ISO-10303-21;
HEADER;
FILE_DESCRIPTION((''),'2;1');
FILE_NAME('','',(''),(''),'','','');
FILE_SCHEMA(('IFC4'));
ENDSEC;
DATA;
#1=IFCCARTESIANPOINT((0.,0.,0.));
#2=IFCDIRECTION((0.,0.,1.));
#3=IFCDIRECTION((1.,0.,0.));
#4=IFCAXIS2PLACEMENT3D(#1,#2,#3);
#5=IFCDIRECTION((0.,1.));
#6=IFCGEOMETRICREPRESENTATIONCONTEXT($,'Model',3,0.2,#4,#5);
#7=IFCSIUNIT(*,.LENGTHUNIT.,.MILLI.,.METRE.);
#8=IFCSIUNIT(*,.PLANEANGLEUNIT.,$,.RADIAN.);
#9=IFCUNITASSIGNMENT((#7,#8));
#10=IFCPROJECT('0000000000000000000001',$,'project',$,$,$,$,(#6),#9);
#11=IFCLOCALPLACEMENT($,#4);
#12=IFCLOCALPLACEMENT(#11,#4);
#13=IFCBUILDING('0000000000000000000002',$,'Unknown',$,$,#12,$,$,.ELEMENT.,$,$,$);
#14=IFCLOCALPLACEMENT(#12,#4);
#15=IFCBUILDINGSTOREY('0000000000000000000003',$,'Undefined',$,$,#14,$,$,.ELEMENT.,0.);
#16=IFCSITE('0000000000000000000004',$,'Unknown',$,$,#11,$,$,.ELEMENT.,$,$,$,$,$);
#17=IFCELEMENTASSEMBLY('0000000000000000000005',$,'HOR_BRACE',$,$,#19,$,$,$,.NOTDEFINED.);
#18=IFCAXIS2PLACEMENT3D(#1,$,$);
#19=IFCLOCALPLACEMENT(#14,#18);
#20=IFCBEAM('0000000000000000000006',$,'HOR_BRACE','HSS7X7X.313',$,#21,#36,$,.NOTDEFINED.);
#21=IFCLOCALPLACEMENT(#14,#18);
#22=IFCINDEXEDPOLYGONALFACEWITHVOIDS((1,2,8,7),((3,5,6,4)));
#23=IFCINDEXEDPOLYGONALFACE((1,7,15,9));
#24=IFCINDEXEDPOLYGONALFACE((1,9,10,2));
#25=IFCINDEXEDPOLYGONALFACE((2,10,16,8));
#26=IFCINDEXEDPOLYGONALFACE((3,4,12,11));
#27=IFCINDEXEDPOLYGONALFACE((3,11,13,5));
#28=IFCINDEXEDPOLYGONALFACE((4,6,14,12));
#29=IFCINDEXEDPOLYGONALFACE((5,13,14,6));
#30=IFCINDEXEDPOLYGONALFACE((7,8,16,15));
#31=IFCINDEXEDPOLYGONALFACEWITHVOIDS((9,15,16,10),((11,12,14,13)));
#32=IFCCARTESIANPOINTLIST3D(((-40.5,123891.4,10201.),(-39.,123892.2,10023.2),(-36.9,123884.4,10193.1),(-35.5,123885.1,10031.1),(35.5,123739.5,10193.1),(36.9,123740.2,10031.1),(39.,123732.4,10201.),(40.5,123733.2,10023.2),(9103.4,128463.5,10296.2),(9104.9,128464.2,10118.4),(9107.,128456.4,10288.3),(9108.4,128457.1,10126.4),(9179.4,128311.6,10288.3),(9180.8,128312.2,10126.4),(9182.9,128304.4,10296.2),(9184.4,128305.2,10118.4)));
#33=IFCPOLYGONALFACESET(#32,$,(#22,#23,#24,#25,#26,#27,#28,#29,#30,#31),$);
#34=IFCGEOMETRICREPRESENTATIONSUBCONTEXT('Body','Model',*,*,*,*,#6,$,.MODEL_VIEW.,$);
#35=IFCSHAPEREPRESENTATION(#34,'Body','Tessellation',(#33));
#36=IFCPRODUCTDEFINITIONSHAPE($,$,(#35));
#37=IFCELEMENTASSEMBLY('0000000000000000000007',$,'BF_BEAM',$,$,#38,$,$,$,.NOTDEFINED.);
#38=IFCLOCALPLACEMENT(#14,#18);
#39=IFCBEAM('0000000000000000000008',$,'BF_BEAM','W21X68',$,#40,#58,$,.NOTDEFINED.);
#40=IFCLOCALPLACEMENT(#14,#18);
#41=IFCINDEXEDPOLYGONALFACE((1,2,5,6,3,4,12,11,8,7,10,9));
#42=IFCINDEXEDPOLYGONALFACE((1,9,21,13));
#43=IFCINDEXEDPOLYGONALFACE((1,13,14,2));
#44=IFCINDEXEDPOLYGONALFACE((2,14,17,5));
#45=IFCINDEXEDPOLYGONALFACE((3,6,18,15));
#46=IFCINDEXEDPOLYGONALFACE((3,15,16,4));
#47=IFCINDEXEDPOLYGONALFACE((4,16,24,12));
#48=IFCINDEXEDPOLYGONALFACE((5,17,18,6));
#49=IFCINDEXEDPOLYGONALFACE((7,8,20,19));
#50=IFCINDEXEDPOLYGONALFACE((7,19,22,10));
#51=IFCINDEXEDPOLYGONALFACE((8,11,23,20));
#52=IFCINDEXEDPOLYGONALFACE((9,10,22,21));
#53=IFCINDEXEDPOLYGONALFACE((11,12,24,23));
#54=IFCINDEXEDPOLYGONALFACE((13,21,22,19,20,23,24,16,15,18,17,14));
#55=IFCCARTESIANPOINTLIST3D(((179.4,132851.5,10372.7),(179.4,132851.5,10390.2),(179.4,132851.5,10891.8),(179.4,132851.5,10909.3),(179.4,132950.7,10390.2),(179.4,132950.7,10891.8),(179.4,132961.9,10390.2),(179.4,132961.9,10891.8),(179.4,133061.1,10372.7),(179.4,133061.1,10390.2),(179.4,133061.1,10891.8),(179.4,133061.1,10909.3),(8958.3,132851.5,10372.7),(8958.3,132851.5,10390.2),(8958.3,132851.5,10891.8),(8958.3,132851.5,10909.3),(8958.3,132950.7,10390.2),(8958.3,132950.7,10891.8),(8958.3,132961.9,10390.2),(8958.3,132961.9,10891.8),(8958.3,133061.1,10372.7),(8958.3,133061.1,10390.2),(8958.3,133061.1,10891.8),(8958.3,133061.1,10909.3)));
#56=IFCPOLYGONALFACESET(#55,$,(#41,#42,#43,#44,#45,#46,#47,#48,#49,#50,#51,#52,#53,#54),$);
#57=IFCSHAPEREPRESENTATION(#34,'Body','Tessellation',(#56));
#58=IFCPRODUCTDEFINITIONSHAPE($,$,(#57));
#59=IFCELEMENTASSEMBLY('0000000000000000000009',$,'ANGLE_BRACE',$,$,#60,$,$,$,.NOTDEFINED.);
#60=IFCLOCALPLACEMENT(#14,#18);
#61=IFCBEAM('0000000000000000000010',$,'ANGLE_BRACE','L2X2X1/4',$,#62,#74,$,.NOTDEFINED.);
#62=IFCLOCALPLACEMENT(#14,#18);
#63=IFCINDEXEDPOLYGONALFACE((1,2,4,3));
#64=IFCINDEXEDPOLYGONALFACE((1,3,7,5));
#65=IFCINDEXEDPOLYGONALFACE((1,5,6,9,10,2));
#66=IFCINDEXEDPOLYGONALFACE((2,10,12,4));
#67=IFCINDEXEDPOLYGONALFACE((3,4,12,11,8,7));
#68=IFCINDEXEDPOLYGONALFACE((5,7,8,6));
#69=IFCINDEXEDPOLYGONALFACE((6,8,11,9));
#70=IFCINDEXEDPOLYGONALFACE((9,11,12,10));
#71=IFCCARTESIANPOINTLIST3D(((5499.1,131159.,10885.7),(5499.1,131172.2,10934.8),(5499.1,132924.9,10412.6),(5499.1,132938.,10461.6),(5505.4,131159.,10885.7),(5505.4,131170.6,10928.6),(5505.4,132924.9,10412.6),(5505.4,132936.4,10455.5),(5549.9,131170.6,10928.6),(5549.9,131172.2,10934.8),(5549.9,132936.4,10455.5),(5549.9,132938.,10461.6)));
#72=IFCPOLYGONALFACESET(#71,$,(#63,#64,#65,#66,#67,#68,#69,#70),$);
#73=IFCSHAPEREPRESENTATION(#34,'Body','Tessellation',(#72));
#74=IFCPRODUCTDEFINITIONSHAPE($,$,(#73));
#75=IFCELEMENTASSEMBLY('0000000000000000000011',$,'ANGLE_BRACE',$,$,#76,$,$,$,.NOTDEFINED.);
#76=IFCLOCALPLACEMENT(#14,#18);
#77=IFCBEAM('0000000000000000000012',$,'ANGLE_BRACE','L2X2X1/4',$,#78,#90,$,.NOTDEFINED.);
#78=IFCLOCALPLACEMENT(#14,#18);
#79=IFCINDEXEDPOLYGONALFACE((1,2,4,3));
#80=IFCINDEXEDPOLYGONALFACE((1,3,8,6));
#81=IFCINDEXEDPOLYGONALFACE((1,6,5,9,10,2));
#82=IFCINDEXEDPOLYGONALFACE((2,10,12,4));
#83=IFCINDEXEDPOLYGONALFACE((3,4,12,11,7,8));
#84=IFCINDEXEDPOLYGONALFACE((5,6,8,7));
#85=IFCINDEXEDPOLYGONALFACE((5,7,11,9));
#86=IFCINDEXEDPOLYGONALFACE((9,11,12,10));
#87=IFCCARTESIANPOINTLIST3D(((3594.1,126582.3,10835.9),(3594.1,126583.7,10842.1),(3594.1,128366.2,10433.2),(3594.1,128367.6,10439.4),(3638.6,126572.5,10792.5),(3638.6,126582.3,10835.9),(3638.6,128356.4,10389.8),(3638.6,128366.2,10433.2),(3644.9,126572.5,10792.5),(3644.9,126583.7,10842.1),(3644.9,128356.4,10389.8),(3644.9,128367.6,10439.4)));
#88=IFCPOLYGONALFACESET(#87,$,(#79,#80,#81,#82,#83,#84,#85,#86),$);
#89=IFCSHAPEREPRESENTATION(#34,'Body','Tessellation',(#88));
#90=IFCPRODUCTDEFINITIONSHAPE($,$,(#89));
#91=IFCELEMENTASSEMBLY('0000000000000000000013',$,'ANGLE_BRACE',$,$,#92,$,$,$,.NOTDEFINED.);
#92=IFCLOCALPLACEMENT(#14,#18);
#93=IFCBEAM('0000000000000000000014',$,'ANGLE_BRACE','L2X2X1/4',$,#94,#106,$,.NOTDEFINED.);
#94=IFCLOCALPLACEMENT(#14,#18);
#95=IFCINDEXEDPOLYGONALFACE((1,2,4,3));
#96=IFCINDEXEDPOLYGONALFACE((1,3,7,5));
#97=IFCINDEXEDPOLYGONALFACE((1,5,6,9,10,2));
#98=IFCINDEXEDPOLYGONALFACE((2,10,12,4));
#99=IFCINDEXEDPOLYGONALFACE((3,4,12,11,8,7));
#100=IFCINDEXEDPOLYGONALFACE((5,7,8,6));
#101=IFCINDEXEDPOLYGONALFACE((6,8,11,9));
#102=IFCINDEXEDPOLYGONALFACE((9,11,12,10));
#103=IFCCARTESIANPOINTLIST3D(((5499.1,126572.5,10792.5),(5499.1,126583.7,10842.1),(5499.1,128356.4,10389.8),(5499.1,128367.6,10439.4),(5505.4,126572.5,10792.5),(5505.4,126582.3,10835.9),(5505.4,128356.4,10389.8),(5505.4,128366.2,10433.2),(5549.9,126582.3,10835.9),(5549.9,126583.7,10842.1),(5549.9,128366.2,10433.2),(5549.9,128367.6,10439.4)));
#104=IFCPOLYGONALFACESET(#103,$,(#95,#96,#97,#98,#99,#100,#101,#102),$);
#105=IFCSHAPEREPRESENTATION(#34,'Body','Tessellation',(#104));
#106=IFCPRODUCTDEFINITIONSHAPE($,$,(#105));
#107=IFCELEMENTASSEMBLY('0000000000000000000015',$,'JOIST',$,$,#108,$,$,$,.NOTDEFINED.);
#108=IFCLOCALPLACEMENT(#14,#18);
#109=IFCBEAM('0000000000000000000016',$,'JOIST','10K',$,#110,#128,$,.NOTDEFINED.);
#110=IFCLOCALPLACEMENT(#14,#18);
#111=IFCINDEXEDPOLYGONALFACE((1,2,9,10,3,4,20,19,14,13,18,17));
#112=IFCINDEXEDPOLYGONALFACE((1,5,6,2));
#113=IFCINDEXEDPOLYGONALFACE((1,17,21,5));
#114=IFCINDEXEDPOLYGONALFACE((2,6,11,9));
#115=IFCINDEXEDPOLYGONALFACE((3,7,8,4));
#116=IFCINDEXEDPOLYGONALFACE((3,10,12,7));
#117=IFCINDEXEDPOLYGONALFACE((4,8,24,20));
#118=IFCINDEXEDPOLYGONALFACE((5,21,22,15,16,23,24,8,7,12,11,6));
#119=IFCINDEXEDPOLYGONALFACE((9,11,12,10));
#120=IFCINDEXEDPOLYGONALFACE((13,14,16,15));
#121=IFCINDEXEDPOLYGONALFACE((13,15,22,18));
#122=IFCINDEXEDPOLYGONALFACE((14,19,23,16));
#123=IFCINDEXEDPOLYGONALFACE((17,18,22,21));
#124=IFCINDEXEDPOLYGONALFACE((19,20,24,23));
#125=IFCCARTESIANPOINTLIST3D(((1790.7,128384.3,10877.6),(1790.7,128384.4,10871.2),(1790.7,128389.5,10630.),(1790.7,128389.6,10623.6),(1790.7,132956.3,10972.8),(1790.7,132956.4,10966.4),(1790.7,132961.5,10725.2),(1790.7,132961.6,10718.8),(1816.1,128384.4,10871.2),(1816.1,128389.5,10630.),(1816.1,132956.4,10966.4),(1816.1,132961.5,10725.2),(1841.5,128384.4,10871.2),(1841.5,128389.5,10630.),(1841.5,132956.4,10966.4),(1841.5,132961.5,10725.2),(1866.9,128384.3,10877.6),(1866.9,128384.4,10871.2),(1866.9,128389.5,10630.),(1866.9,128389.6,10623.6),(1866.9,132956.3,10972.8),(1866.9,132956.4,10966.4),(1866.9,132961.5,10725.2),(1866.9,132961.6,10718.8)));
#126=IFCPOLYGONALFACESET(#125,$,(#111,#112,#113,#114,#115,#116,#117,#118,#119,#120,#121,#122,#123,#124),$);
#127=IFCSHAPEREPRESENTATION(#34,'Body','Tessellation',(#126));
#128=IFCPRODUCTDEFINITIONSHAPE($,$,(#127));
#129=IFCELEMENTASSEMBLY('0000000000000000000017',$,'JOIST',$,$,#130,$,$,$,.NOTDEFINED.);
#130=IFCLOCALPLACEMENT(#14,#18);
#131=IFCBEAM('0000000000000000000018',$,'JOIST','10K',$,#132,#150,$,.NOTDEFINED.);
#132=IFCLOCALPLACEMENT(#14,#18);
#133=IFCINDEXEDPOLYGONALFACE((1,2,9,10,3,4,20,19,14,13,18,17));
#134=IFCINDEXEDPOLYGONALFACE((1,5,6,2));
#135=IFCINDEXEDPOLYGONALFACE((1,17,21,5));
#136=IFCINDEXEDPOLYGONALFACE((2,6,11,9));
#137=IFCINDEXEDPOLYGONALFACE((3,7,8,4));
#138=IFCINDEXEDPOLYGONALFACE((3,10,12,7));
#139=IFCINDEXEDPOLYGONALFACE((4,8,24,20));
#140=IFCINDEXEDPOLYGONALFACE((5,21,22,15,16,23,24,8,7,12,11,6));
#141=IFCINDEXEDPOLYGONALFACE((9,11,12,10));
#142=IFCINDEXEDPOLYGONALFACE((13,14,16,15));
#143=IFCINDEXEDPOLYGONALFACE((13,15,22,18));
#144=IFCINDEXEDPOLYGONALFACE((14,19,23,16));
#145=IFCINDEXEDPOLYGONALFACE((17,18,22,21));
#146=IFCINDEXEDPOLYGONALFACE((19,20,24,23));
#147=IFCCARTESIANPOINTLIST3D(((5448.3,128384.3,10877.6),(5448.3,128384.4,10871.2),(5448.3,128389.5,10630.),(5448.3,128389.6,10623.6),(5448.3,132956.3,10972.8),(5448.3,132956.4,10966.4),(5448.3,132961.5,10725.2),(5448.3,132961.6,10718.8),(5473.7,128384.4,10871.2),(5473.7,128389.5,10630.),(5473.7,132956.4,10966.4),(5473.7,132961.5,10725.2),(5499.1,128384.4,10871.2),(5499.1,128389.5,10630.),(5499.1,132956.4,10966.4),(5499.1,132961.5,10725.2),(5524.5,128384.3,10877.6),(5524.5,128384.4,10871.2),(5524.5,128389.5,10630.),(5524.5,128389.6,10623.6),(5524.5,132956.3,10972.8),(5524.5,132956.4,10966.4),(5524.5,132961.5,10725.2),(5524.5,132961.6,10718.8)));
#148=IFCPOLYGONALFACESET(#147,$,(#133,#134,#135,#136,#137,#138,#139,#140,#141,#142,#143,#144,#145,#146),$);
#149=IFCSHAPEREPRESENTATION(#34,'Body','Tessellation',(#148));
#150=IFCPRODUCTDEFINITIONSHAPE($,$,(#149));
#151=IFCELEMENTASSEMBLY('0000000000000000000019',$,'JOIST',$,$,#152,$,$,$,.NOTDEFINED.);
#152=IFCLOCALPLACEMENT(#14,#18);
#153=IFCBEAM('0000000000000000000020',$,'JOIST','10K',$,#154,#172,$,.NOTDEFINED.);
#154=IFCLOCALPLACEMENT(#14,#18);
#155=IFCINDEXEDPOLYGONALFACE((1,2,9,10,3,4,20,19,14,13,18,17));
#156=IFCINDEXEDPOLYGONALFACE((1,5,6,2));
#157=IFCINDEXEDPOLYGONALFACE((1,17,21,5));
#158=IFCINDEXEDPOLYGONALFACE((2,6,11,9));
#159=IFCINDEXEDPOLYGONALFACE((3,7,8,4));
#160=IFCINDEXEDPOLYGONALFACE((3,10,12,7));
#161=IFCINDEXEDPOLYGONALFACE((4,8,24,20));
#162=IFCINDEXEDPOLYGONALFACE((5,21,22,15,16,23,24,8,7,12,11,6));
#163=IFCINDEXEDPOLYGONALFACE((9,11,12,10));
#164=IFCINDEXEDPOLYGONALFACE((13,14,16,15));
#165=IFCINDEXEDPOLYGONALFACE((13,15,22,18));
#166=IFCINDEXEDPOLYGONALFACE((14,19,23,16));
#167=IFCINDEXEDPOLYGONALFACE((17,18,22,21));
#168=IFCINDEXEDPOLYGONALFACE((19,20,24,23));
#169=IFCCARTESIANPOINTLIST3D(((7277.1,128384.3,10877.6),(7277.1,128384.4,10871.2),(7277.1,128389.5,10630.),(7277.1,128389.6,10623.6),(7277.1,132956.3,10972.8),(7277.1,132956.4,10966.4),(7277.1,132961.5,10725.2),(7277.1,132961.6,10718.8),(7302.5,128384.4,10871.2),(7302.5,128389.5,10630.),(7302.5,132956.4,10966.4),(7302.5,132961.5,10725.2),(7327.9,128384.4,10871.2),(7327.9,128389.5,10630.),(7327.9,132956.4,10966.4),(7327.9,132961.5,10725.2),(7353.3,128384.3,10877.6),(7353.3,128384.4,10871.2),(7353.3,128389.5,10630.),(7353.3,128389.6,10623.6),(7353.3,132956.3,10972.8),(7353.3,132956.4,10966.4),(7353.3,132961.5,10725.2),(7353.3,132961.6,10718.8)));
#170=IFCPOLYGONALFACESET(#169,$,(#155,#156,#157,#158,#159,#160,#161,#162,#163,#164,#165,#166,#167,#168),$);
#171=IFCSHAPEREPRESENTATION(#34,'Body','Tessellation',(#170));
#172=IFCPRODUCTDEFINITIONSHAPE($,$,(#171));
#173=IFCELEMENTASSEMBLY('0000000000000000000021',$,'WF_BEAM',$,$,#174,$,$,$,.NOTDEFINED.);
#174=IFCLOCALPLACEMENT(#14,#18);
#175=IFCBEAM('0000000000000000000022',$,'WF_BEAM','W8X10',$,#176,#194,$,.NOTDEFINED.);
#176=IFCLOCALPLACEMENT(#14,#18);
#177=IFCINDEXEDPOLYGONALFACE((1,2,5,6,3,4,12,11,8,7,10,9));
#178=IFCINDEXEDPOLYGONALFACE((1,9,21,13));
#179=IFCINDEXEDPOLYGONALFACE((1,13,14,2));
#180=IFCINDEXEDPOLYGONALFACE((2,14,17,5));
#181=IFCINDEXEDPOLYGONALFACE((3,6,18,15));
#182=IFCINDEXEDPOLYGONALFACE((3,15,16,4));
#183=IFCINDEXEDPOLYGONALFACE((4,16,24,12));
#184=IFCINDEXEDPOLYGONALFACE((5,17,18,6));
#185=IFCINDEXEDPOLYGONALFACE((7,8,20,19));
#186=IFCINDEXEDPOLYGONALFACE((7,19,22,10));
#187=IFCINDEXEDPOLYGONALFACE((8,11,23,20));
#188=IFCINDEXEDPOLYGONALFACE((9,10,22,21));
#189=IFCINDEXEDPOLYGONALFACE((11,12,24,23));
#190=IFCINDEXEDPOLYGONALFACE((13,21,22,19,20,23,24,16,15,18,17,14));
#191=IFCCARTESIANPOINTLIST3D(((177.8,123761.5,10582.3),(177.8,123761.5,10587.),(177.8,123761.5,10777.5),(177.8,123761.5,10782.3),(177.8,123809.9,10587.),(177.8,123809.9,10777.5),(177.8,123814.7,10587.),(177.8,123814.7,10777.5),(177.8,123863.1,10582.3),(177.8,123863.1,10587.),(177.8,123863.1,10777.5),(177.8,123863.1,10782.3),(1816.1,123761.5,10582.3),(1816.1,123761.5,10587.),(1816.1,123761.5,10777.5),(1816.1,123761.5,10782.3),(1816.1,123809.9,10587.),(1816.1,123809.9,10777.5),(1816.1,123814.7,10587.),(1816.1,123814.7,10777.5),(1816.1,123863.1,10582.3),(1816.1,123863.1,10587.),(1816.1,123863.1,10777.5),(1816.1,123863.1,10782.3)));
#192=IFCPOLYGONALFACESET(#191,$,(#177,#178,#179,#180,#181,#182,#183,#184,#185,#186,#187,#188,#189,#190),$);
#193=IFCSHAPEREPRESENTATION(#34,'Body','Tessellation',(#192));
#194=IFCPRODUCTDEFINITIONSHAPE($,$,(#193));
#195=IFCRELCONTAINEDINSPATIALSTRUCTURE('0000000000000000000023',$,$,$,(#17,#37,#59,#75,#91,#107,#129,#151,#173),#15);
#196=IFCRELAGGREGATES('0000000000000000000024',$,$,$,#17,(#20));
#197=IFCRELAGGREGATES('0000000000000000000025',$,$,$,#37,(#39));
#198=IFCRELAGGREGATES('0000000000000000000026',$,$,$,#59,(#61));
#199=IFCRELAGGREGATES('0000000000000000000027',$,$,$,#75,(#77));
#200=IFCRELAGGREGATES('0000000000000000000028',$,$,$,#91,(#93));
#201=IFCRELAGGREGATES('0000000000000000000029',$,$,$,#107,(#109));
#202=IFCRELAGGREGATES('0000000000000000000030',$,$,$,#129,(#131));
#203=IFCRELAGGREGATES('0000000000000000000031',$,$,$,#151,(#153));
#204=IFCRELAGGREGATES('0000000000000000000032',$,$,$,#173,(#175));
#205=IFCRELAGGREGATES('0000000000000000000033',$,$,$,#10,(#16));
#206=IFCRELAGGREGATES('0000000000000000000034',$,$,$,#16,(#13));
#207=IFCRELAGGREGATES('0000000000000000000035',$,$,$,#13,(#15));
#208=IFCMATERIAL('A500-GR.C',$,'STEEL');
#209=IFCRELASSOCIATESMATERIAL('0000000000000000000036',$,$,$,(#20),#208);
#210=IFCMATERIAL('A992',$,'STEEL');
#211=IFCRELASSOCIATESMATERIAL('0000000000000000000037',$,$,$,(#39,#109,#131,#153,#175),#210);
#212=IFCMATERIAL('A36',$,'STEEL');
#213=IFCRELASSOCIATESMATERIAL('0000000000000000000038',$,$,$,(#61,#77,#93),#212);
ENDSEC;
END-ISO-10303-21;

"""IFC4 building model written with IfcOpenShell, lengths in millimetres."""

from ifc_helpers import new_model, si_unit, direction, frame, origin_with_axes, place, context, subcontext, project, spatial, line, indexed_curve, outline, extrude, material, element, aggregate, save


model = new_model("IFC4")

# Units and contexts
model_context = context("Model", 3, precision=0.2, world=origin_with_axes(), true_north=direction((0.0, 1.0)))
body_context = subcontext(model_context, "Body", "Model", "MODEL_VIEW")
ifc_project = project(units=[si_unit("LENGTHUNIT", "METRE", prefix="MILLI"), si_unit("PLANEANGLEUNIT", "RADIAN")], contexts=[model_context])

# Site, building, storey
site_placement = place(None, origin_with_axes())
site = spatial("IfcSite", under=ifc_project, at=site_placement, Name="Unknown", CompositionType="ELEMENT")
building_placement = place(site_placement, origin_with_axes())
building = spatial("IfcBuilding", under=site, at=building_placement, Name="Unknown", CompositionType="ELEMENT")
storey_placement = place(building_placement, origin_with_axes())
storey = spatial("IfcBuildingStorey", under=building, at=storey_placement, Name="Undefined", CompositionType="ELEMENT", Elevation=0.0)

# Element assemblies, beams
assembly_1_placement = place(storey_placement, frame((0.0, 123812.3, 10112.1), z_axis=(0.447218, -0.894425, 0.0), x_axis=(0.894386, 0.447199, 0.009317)))
assembly_1 = element("IfcElementAssembly", 1, at=assembly_1_placement, inside=storey, Name="HOR_BRACE", PredefinedType="NOTDEFINED")
ifc_material_1 = material(Name="A500-GR.C", Category="STEEL")
beam_1_placement = place(assembly_1_placement, origin_with_axes())
beam_1 = element("IfcBeam", 2, at=beam_1_placement, material=ifc_material_1, Name="HOR_BRACE", Description="HSS7X7X.313", PredefinedType="NOTDEFINED", context=body_context, shape_type="SolidModel", body=[
    extrude(outline(indexed_curve([(-88.9, -88.9), (88.9, -88.9), (88.9, 88.9), (-88.9, 88.9)], segments=[line(1, 2, 3, 4, 1)]), holes=[indexed_curve([(-81.0, -81.0), (-81.0, 81.0), (81.0, 81.0), (81.0, -81.0)], segments=[line(1, 2, 3, 4, 1)])]), frame((0.0, 0.0, 0.0), z_axis=(-1.0, 0.0, 0.0), x_axis=(0.0, 0.0, 1.0)), (0.0, 0.0, -1.0), 10223.7),
])
aggregate(assembly_1, [beam_1])
assembly_2_placement = place(storey_placement, frame((179.4, 132956.3, 10641.0), z_axis=(0.0, -1.0, 0.0), x_axis=(1.0, 0.0, 0.0)))
assembly_2 = element("IfcElementAssembly", 3, at=assembly_2_placement, inside=storey, Name="BF_BEAM", PredefinedType="NOTDEFINED")
ifc_material_2 = material(Name="A992", Category="STEEL")
beam_2_placement = place(assembly_2_placement, origin_with_axes())
beam_2 = element("IfcBeam", 4, at=beam_2_placement, material=ifc_material_2, Name="BF_BEAM", Description="W21X68", PredefinedType="NOTDEFINED", context=body_context, shape_type="SolidModel", body=[
    extrude(outline(indexed_curve([(-104.8, -268.3), (104.8, -268.3), (104.8, -250.8), (5.6, -250.8), (5.6, 250.8), (104.8, 250.8), (104.8, 268.3), (-104.8, 268.3), (-104.8, 250.8), (-5.6, 250.8), (-5.6, -250.8), (-104.8, -250.8)], segments=[line(1, 2, 3, 4, 5, 6, 7, 8, 9, 10, 11, 12, 1)])), frame((0.0, 0.0, 0.0), z_axis=(-1.0, 0.0, 0.0), x_axis=(0.0, 0.0, 1.0)), (0.0, 0.0, -1.0), 8778.9),
])
aggregate(assembly_2, [beam_2])
assembly_3_placement = place(storey_placement, frame((5524.5, 131165.6, 10910.2), z_axis=(0.0, -0.258819, -0.965926), x_axis=(0.0, 0.965926, -0.258819)))
assembly_3 = element("IfcElementAssembly", 5, at=assembly_3_placement, inside=storey, Name="ANGLE_BRACE", PredefinedType="NOTDEFINED")
ifc_material_3 = material(Name="A36", Category="STEEL")
beam_3_placement = place(assembly_3_placement, origin_with_axes())
beam_3 = element("IfcBeam", 6, at=beam_3_placement, material=ifc_material_3, Name="ANGLE_BRACE", Description="L2X2X1/4", PredefinedType="NOTDEFINED", context=body_context, shape_type="SolidModel", body=[
    extrude(outline(indexed_curve([(-25.4, -25.4), (25.4, -25.4), (25.4, -19.1), (-19.1, -19.1), (-19.1, 25.4), (-25.4, 25.4)], segments=[line(1, 2, 3, 4, 5, 6, 1)])), frame((0.0, 0.0, 0.0), z_axis=(-1.0, 0.0, 0.0), x_axis=(0.0, 0.0, 1.0)), (0.0, 0.0, -1.0), 1828.1),
])
aggregate(assembly_3, [beam_3])
assembly_4_placement = place(storey_placement, frame((3619.5, 126578.1, 10817.3), z_axis=(-1.0, 0.0, 0.0), x_axis=(0.0, 0.97546, -0.220178)))
assembly_4 = element("IfcElementAssembly", 7, at=assembly_4_placement, inside=storey, Name="ANGLE_BRACE", PredefinedType="NOTDEFINED")
beam_4_placement = place(assembly_4_placement, origin_with_axes())
beam_4 = element("IfcBeam", 8, at=beam_4_placement, material=ifc_material_3, Name="ANGLE_BRACE", Description="L2X2X1/4", PredefinedType="NOTDEFINED", context=body_context, shape_type="SolidModel", body=[
    extrude(outline(indexed_curve([(-25.4, -25.4), (25.4, -25.4), (25.4, -19.1), (-19.1, -19.1), (-19.1, 25.4), (-25.4, 25.4)], segments=[line(1, 2, 3, 4, 5, 6, 1)])), frame((0.0, 0.0, 0.0), z_axis=(-1.0, 0.0, 0.0), x_axis=(0.0, 0.0, 1.0)), (0.0, 0.0, -1.0), 1828.8),
])
aggregate(assembly_4, [beam_4])
assembly_5_placement = place(storey_placement, frame((5524.5, 126578.1, 10817.3), z_axis=(0.0, -0.220178, -0.97546), x_axis=(0.0, 0.97546, -0.220178)))
assembly_5 = element("IfcElementAssembly", 9, at=assembly_5_placement, inside=storey, Name="ANGLE_BRACE", PredefinedType="NOTDEFINED")
beam_5_placement = place(assembly_5_placement, origin_with_axes())
beam_5 = element("IfcBeam", 10, at=beam_5_placement, material=ifc_material_3, Name="ANGLE_BRACE", Description="L2X2X1/4", PredefinedType="NOTDEFINED", context=body_context, shape_type="SolidModel", body=[
    extrude(outline(indexed_curve([(-25.4, -25.4), (25.4, -25.4), (25.4, -19.1), (-19.1, -19.1), (-19.1, 25.4), (-25.4, 25.4)], segments=[line(1, 2, 3, 4, 5, 6, 1)])), frame((0.0, 0.0, 0.0), z_axis=(-1.0, 0.0, 0.0), x_axis=(0.0, 0.0, 1.0)), (0.0, 0.0, -1.0), 1828.8),
])
aggregate(assembly_5, [beam_5])
assembly_6_placement = place(storey_placement, frame((1828.8, 128386.9, 10750.6), z_axis=(1.0, 0.0, 0.0), x_axis=(0.0, 0.999783, 0.020819)))
assembly_6 = element("IfcElementAssembly", 11, at=assembly_6_placement, inside=storey, Name="JOIST", PredefinedType="NOTDEFINED")
beam_6_placement = place(assembly_6_placement, origin_with_axes())
beam_6 = element("IfcBeam", 12, at=beam_6_placement, material=ifc_material_2, Name="JOIST", Description="10K", PredefinedType="NOTDEFINED", context=body_context, shape_type="SolidModel", body=[
    extrude(outline(indexed_curve([(-38.1, -127.0), (38.1, -127.0), (38.1, -120.7), (12.7, -120.7), (12.7, 120.7), (38.1, 120.7), (38.1, 127.0), (-38.1, 127.0), (-38.1, 120.7), (-12.7, 120.7), (-12.7, -120.7), (-38.1, -120.7)], segments=[line(1, 2, 3, 4, 5, 6, 7, 8, 9, 10, 11, 12, 1)])), frame((0.0, 0.0, 0.0), z_axis=(-1.0, 0.0, 0.0), x_axis=(0.0, 0.0, 1.0)), (0.0, 0.0, -1.0), 4573.0),
])
aggregate(assembly_6, [beam_6])
assembly_7_placement = place(storey_placement, frame((5486.4, 128386.9, 10750.6), z_axis=(1.0, 0.0, 0.0), x_axis=(0.0, 0.999783, 0.020819)))
assembly_7 = element("IfcElementAssembly", 13, at=assembly_7_placement, inside=storey, Name="JOIST", PredefinedType="NOTDEFINED")
beam_7_placement = place(assembly_7_placement, origin_with_axes())
beam_7 = element("IfcBeam", 14, at=beam_7_placement, material=ifc_material_2, Name="JOIST", Description="10K", PredefinedType="NOTDEFINED", context=body_context, shape_type="SolidModel", body=[
    extrude(outline(indexed_curve([(-38.1, -127.0), (38.1, -127.0), (38.1, -120.7), (12.7, -120.7), (12.7, 120.7), (38.1, 120.7), (38.1, 127.0), (-38.1, 127.0), (-38.1, 120.7), (-12.7, 120.7), (-12.7, -120.7), (-38.1, -120.7)], segments=[line(1, 2, 3, 4, 5, 6, 7, 8, 9, 10, 11, 12, 1)])), frame((0.0, 0.0, 0.0), z_axis=(-1.0, 0.0, 0.0), x_axis=(0.0, 0.0, 1.0)), (0.0, 0.0, -1.0), 4573.0),
])
aggregate(assembly_7, [beam_7])
assembly_8_placement = place(storey_placement, frame((7315.2, 128386.9, 10750.6), z_axis=(1.0, 0.0, 0.0), x_axis=(0.0, 0.999783, 0.020819)))
assembly_8 = element("IfcElementAssembly", 15, at=assembly_8_placement, inside=storey, Name="JOIST", PredefinedType="NOTDEFINED")
beam_8_placement = place(assembly_8_placement, origin_with_axes())
beam_8 = element("IfcBeam", 16, at=beam_8_placement, material=ifc_material_2, Name="JOIST", Description="10K", PredefinedType="NOTDEFINED", context=body_context, shape_type="SolidModel", body=[
    extrude(outline(indexed_curve([(-38.1, -127.0), (38.1, -127.0), (38.1, -120.7), (12.7, -120.7), (12.7, 120.7), (38.1, 120.7), (38.1, 127.0), (-38.1, 127.0), (-38.1, 120.7), (-12.7, 120.7), (-12.7, -120.7), (-38.1, -120.7)], segments=[line(1, 2, 3, 4, 5, 6, 7, 8, 9, 10, 11, 12, 1)])), frame((0.0, 0.0, 0.0), z_axis=(-1.0, 0.0, 0.0), x_axis=(0.0, 0.0, 1.0)), (0.0, 0.0, -1.0), 4573.0),
])
aggregate(assembly_8, [beam_8])
assembly_9_placement = place(storey_placement, frame((177.8, 123812.3, 10682.3), z_axis=(0.0, -1.0, 0.0), x_axis=(1.0, 0.0, 0.0)))
assembly_9 = element("IfcElementAssembly", 17, at=assembly_9_placement, inside=storey, Name="WF_BEAM", PredefinedType="NOTDEFINED")
beam_9_placement = place(assembly_9_placement, origin_with_axes())
beam_9 = element("IfcBeam", 18, at=beam_9_placement, material=ifc_material_2, Name="WF_BEAM", Description="W8X10", PredefinedType="NOTDEFINED", context=body_context, shape_type="SolidModel", body=[
    extrude(outline(indexed_curve([(-50.8, -100.0), (50.8, -100.0), (50.8, -95.2), (2.4, -95.2), (2.4, 95.2), (50.8, 95.2), (50.8, 100.0), (-50.8, 100.0), (-50.8, 95.2), (-2.4, 95.2), (-2.4, -95.2), (-50.8, -95.2)], segments=[line(1, 2, 3, 4, 5, 6, 7, 8, 9, 10, 11, 12, 1)])), frame((0.0, 0.0, 0.0), z_axis=(-1.0, 0.0, 0.0), x_axis=(0.0, 0.0, 1.0)), (0.0, 0.0, -1.0), 1638.3),
])
aggregate(assembly_9, [beam_9])

save(model, "model.ifc")
